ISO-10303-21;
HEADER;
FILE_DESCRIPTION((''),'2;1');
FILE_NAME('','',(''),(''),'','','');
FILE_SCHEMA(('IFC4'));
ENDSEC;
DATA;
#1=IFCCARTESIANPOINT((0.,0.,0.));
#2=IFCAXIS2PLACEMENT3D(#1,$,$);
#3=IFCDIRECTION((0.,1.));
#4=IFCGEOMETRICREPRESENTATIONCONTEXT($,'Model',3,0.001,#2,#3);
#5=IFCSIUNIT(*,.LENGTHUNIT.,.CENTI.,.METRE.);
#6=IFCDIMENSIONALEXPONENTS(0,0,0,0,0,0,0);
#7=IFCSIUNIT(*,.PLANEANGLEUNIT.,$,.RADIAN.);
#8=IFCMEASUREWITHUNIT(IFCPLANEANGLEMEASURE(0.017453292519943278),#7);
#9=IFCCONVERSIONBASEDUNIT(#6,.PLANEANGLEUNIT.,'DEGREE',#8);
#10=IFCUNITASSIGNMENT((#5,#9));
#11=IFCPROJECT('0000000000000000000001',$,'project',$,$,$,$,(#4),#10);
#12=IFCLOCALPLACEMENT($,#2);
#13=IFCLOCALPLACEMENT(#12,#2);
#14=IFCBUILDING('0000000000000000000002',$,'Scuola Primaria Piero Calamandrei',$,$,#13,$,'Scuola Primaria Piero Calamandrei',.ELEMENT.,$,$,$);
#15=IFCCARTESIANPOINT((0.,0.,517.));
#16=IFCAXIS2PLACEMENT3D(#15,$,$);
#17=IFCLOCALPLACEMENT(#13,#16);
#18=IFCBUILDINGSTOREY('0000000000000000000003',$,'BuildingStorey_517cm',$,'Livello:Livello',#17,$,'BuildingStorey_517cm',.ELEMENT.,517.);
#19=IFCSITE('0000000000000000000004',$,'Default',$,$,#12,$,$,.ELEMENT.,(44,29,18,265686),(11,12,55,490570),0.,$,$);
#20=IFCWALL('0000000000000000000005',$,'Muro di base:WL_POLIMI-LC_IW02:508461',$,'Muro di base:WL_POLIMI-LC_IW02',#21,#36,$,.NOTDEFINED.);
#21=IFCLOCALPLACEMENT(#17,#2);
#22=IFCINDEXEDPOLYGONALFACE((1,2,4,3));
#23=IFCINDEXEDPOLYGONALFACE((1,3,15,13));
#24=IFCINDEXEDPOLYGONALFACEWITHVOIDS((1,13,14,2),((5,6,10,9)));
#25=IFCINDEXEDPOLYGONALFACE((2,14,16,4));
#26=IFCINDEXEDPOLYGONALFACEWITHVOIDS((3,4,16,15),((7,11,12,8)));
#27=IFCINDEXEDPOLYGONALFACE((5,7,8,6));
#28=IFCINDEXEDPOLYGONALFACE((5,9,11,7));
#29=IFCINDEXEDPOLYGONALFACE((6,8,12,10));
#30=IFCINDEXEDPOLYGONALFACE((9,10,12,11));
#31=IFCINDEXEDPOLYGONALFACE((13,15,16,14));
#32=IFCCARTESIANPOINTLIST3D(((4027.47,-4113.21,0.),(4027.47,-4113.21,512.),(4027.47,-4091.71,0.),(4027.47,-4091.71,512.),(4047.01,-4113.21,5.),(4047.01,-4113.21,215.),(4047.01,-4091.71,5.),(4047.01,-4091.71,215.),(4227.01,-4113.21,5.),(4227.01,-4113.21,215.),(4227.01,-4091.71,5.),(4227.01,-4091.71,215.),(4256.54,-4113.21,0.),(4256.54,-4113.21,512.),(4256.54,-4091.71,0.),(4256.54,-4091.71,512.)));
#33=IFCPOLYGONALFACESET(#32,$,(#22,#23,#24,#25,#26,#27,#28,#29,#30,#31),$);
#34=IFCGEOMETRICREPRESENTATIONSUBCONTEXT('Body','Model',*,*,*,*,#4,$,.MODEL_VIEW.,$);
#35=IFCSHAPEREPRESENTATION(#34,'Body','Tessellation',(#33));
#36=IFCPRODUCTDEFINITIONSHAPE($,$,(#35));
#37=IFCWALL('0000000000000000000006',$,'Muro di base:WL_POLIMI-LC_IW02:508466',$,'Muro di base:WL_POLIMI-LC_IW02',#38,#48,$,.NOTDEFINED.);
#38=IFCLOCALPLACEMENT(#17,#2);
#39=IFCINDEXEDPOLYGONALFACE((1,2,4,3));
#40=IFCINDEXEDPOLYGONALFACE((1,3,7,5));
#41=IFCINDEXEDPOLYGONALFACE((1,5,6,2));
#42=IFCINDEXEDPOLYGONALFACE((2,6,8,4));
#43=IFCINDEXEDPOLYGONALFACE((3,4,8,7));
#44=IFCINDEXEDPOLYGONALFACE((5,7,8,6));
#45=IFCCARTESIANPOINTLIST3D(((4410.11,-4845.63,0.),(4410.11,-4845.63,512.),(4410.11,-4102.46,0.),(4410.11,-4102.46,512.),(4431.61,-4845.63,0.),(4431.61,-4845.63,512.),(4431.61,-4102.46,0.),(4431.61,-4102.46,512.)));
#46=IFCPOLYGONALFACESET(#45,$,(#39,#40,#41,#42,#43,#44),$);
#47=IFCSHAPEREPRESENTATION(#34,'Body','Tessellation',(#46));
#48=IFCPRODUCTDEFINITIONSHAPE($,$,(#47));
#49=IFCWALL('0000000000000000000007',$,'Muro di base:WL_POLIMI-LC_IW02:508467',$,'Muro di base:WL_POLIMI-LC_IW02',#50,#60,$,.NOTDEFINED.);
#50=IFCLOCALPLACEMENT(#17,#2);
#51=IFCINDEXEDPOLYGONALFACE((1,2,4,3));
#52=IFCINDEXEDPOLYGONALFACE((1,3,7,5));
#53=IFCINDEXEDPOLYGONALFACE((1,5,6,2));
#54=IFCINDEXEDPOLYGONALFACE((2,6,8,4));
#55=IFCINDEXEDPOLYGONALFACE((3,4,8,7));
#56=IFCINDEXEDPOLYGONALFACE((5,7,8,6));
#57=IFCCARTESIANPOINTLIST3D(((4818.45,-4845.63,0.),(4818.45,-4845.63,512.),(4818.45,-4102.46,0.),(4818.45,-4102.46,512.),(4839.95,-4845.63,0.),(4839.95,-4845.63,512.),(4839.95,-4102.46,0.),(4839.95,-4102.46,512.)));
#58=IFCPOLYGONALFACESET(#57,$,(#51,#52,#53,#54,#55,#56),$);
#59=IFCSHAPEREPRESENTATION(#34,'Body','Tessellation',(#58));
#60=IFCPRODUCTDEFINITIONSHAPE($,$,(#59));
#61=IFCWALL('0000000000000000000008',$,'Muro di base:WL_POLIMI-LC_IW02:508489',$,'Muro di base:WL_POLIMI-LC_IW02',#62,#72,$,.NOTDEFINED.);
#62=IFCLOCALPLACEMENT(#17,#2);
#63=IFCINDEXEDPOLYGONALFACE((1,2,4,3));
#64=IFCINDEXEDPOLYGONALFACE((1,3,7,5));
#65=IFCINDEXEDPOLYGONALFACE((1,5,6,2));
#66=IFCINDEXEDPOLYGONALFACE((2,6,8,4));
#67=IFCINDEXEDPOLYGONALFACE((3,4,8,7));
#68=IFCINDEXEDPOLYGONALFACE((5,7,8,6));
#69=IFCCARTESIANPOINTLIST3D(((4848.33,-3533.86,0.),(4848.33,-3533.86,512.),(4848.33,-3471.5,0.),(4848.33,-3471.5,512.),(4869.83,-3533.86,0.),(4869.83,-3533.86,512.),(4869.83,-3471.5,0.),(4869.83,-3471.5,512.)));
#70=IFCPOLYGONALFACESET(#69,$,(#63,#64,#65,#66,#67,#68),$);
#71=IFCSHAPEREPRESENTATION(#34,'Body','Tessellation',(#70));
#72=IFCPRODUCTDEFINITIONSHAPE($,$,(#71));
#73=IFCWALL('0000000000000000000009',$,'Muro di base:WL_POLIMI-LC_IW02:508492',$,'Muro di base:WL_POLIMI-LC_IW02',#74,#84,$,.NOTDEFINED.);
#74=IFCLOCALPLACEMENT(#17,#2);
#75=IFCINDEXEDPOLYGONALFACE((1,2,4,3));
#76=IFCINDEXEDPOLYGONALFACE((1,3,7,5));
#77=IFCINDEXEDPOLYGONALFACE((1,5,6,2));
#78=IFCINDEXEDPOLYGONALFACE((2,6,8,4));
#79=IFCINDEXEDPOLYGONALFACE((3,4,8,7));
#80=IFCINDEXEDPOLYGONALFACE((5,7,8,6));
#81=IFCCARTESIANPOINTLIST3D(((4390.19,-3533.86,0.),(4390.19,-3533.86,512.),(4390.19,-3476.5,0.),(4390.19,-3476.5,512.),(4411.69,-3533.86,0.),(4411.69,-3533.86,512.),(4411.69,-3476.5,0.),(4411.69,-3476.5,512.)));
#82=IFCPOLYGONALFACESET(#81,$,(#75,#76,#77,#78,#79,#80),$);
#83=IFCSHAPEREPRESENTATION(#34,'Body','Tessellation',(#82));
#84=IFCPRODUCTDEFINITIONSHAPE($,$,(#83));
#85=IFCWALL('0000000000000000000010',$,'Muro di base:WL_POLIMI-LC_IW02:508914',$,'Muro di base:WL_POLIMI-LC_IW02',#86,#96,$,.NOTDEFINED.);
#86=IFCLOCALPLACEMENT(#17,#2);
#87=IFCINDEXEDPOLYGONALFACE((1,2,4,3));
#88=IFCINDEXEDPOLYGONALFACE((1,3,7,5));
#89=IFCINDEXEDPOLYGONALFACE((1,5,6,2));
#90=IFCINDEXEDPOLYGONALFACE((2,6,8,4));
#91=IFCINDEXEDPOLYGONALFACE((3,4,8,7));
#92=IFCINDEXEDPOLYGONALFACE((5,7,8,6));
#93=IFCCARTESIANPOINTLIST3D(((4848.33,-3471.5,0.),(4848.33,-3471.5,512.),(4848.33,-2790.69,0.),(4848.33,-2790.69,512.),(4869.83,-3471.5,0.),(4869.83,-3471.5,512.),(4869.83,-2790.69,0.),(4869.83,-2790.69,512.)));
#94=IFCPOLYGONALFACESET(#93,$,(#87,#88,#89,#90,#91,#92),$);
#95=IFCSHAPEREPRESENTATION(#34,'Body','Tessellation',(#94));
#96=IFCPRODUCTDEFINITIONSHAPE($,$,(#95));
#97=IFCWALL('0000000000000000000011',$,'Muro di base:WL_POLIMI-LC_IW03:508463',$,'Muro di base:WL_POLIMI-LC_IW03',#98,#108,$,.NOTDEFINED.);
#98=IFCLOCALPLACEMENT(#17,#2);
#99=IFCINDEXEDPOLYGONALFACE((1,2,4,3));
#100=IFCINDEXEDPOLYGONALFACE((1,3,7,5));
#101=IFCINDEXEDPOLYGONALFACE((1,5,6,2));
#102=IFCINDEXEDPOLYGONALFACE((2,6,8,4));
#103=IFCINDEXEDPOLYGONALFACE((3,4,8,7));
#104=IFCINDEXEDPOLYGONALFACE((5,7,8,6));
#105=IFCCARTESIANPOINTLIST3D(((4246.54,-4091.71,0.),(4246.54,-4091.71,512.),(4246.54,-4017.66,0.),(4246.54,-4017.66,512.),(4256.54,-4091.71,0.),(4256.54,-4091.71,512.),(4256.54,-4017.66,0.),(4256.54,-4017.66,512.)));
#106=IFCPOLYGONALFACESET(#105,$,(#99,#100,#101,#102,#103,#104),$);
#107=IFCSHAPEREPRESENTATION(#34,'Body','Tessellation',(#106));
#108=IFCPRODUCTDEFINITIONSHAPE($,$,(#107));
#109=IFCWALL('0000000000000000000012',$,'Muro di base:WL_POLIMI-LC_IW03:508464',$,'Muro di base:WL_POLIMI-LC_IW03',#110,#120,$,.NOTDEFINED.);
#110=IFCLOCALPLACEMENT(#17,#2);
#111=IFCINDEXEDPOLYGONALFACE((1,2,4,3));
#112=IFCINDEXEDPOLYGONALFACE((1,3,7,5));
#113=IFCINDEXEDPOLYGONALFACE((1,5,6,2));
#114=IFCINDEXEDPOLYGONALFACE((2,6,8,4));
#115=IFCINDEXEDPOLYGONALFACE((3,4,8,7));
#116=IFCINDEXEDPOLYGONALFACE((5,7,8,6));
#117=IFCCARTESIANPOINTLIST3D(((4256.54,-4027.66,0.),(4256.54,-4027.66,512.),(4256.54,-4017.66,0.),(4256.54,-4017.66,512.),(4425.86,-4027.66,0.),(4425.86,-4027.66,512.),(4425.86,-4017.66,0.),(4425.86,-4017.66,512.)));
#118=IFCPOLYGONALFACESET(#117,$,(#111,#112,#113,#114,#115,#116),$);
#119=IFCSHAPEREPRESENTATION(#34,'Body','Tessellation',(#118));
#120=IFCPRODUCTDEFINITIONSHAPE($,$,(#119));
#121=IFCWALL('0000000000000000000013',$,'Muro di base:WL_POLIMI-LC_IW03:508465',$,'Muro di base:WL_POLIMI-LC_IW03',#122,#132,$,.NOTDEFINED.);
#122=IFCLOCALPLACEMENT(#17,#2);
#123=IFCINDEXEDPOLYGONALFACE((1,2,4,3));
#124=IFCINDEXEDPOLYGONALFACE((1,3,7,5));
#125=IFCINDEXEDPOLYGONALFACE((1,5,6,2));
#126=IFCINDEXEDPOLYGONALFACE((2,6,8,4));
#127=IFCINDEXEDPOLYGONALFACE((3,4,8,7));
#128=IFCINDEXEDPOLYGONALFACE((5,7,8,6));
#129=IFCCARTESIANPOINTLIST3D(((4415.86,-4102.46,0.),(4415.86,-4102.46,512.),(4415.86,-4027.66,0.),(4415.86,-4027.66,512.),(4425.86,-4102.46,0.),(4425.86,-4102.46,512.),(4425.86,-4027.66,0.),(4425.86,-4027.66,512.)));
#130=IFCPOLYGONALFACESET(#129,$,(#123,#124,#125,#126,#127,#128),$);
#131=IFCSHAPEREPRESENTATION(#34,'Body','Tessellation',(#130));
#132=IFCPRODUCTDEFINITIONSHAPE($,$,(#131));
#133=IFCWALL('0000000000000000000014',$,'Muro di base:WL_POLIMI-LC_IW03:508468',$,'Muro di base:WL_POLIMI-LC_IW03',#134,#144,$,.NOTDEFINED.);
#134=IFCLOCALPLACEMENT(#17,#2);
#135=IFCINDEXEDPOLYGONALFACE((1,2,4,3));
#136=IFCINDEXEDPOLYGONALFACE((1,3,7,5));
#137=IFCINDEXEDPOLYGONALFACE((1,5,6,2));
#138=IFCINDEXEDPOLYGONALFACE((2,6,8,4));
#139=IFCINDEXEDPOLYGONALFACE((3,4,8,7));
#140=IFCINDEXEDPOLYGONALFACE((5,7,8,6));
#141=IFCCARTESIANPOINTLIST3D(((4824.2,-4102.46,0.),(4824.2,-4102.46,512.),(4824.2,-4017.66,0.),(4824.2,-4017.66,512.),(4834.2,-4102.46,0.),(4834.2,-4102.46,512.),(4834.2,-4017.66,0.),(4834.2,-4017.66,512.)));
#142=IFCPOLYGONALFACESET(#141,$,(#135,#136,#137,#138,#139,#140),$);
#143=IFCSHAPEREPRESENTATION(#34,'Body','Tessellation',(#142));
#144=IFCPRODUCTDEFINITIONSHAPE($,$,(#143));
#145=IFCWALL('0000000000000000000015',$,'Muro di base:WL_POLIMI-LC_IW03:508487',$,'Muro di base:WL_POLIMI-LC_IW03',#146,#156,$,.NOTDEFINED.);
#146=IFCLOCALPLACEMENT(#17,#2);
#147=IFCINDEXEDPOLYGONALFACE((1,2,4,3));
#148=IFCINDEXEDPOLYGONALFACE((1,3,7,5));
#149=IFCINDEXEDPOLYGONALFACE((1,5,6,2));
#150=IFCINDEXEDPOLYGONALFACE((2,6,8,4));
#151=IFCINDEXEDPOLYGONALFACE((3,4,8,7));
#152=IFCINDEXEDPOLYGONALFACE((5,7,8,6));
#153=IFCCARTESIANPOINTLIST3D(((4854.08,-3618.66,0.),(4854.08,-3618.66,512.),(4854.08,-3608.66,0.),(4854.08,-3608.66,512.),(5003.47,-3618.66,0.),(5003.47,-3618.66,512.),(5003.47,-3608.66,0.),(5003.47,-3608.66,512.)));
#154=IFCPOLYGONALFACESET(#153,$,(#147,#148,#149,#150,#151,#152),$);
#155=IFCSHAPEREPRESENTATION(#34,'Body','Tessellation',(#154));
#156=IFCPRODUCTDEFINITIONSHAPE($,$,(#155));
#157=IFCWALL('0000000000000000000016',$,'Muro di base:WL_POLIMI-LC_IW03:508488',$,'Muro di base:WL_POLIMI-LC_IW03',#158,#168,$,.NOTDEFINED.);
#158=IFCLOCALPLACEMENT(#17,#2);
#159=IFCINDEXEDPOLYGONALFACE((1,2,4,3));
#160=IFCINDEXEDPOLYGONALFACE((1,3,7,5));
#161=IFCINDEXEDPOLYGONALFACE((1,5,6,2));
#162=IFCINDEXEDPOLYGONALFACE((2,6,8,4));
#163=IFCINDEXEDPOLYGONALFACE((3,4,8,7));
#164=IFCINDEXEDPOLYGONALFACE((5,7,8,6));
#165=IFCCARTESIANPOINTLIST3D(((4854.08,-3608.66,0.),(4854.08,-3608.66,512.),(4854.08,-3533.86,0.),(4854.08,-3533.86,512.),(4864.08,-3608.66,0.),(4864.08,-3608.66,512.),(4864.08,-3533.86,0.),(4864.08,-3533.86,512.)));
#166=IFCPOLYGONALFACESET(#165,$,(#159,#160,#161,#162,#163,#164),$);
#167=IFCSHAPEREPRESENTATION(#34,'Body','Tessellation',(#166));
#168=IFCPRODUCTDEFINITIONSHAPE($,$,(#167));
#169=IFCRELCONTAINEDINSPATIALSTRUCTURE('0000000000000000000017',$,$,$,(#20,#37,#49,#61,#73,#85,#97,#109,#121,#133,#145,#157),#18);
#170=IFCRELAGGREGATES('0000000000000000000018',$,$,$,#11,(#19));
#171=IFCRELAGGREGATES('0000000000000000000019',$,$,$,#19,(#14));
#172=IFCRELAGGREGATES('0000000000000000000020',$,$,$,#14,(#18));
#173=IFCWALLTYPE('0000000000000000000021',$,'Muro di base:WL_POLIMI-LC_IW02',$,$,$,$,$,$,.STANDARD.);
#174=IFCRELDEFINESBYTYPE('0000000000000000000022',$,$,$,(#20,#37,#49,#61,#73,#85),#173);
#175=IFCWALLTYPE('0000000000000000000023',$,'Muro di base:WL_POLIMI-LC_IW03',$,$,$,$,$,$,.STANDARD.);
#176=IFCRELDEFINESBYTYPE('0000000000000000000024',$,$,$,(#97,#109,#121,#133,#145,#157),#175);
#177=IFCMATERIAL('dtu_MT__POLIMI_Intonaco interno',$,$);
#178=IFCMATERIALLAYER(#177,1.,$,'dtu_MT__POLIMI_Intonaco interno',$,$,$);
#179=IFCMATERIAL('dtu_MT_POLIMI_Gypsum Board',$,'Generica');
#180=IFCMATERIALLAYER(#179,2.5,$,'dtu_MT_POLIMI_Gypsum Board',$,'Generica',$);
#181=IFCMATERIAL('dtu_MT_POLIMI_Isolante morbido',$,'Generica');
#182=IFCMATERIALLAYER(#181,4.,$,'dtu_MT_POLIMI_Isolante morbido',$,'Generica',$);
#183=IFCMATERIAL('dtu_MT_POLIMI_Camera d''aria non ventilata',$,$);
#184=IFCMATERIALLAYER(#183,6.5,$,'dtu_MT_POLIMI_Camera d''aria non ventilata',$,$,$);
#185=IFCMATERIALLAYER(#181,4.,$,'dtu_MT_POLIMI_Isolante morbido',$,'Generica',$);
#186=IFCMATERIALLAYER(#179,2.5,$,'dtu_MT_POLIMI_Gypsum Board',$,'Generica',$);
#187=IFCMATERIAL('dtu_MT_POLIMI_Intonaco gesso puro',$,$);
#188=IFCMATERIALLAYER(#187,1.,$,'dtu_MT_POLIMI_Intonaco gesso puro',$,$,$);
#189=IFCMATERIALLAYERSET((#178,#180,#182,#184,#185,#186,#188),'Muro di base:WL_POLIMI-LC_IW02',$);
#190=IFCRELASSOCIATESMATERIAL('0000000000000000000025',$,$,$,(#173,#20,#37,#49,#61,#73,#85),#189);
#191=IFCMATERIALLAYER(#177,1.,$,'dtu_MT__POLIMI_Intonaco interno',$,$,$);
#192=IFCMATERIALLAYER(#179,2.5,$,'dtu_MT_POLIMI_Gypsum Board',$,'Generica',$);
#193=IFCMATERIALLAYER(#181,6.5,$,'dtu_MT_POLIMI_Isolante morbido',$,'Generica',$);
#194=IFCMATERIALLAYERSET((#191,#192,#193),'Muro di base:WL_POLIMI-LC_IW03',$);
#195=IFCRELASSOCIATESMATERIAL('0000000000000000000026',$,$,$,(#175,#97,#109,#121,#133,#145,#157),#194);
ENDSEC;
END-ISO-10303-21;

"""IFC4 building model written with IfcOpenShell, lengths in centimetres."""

from ifc_helpers import new_model, entity, si_unit, converted_unit, direction, frame, frame_2d, origin, place, context, subcontext, project, spatial, rectangle, extrude, material, layer, layer_set, layer_usage, type_object, element, save


model = new_model("IFC4")

# Units and contexts
model_context = context("Model", 3, precision=0.001, world=origin(), true_north=direction((0.0, 1.0)))
body_context = subcontext(model_context, "Body", "Model", "MODEL_VIEW")
ifc_project = project(units=[si_unit("LENGTHUNIT", "METRE", prefix="CENTI"), converted_unit("PLANEANGLEUNIT", "DEGREE", entity("IfcPlaneAngleMeasure", 0.017453292519943278), si_unit("PLANEANGLEUNIT", "RADIAN"), dimensions=[0, 0, 0, 0, 0, 0, 0])], contexts=[model_context])

# Site, building, storey
site_placement = place(None, origin())
site = spatial("IfcSite", under=ifc_project, at=site_placement, Name="Default", CompositionType="ELEMENT", RefLatitude=(44, 29, 18, 265686), RefLongitude=(11, 12, 55, 490570), RefElevation=0.0)
building_placement = place(site_placement, origin())
building = spatial("IfcBuilding", under=site, at=building_placement, Name="Scuola Primaria Piero Calamandrei", LongName="Scuola Primaria Piero Calamandrei", CompositionType="ELEMENT")
storey_placement = place(building_placement, frame((0.0, 0.0, 517.0)))
storey = spatial("IfcBuildingStorey", under=building, at=storey_placement, Name="BuildingStorey_517cm", ObjectType="Livello:Livello", LongName="BuildingStorey_517cm", CompositionType="ELEMENT", Elevation=517.0)

# Shared definitions
ifc_material_1 = material(Name="dtu_MT_POLIMI_Isolante morbido", Category="Generica")
ifc_material_2 = material(Name="dtu_MT_POLIMI_Gypsum Board", Category="Generica")
ifc_material_3 = material(Name="dtu_MT__POLIMI_Intonaco interno")

# Wall, opening
ifc_layer_1 = layer(ifc_material_3, 1.0, Name="dtu_MT__POLIMI_Intonaco interno")
ifc_layer_2 = layer(ifc_material_2, 2.5, Name="dtu_MT_POLIMI_Gypsum Board", Category="Generica")
ifc_layer_3 = layer(ifc_material_1, 4.0, Name="dtu_MT_POLIMI_Isolante morbido", Category="Generica")
ifc_material_4 = material(Name="dtu_MT_POLIMI_Camera d'aria non ventilata")
ifc_layer_4 = layer(ifc_material_4, 6.5, Name="dtu_MT_POLIMI_Camera d'aria non ventilata")
ifc_layer_5 = layer(ifc_material_1, 4.0, Name="dtu_MT_POLIMI_Isolante morbido", Category="Generica")
ifc_layer_6 = layer(ifc_material_2, 2.5, Name="dtu_MT_POLIMI_Gypsum Board", Category="Generica")
ifc_material_5 = material(Name="dtu_MT_POLIMI_Intonaco gesso puro")
ifc_layer_7 = layer(ifc_material_5, 1.0, Name="dtu_MT_POLIMI_Intonaco gesso puro")
ifc_layer_set_1 = layer_set([ifc_layer_1, ifc_layer_2, ifc_layer_3, ifc_layer_4, ifc_layer_5, ifc_layer_6, ifc_layer_7], Name="Muro di base:WL_POLIMI-LC_IW02")
ifc_layer_usage_1 = layer_usage(ifc_layer_set_1, "AXIS2", "NEGATIVE", 10.75)
wall_type_1 = type_object("IfcWallType", Name="Muro di base:WL_POLIMI-LC_IW02", PredefinedType="STANDARD", material=ifc_layer_set_1)
wall_1_placement = place(storey_placement, frame((4256.54, -4102.46, 0.0), z_axis=(0.0, 0.0, 1.0), x_axis=(-1.0, 0.0, 0.0)))
wall_1 = element("IfcWall", 1, at=wall_1_placement, inside=storey, type_object=wall_type_1, material=ifc_layer_usage_1, Name="Muro di base:WL_POLIMI-LC_IW02:508461", ObjectType="Muro di base:WL_POLIMI-LC_IW02", PredefinedType="NOTDEFINED", context=body_context, shape_type="SweptSolid", body=[
    extrude(rectangle(XDim=229.07, YDim=21.5, at=frame_2d((114.54, 0.0), x_axis=(-1.0, 0.0))), origin(), (0.0, 0.0, 1.0), 512.0),
])
opening_1_placement = place(wall_1_placement, frame((209.54, 10.75, 5.0)))
element("IfcOpeningElement", 2, at=opening_1_placement, cuts=wall_1, PredefinedType="OPENING", context=body_context, shape_type="SweptSolid", body=[
    extrude(rectangle(XDim=210.0, YDim=180.0, at=frame_2d((105.0, 90.0), x_axis=(-1.0, 0.0))), frame((0.0, 0.0, 0.0), z_axis=(0.0, -1.0, 0.0), x_axis=(0.0, 0.0, 1.0)), (0.0, 0.0, 1.0), 21.5),
])

# Walls
ifc_layer_usage_2 = layer_usage(ifc_layer_set_1, "AXIS2", "NEGATIVE", 10.75)
wall_2_placement = place(storey_placement, frame((4420.86, -4845.63, 0.0), z_axis=(0.0, 0.0, 1.0), x_axis=(0.0, 1.0, 0.0)))
element("IfcWall", 3, at=wall_2_placement, inside=storey, type_object=wall_type_1, material=ifc_layer_usage_2, Name="Muro di base:WL_POLIMI-LC_IW02:508466", ObjectType="Muro di base:WL_POLIMI-LC_IW02", PredefinedType="NOTDEFINED", context=body_context, shape_type="SweptSolid", body=[
    extrude(rectangle(XDim=743.17, YDim=21.5, at=frame_2d((371.58, 0.0), x_axis=(-1.0, 0.0))), origin(), (0.0, 0.0, 1.0), 512.0),
])
ifc_layer_usage_3 = layer_usage(ifc_layer_set_1, "AXIS2", "NEGATIVE", 10.75)
wall_3_placement = place(storey_placement, frame((4829.2, -4102.46, 0.0), z_axis=(0.0, 0.0, 1.0), x_axis=(0.0, -1.0, 0.0)))
element("IfcWall", 4, at=wall_3_placement, inside=storey, type_object=wall_type_1, material=ifc_layer_usage_3, Name="Muro di base:WL_POLIMI-LC_IW02:508467", ObjectType="Muro di base:WL_POLIMI-LC_IW02", PredefinedType="NOTDEFINED", context=body_context, shape_type="SweptSolid", body=[
    extrude(rectangle(XDim=743.17, YDim=21.5, at=frame_2d((371.58, 0.0), x_axis=(-1.0, 0.0))), origin(), (0.0, 0.0, 1.0), 512.0),
])
ifc_layer_usage_4 = layer_usage(ifc_layer_set_1, "AXIS2", "NEGATIVE", 10.75)
wall_4_placement = place(storey_placement, frame((4859.08, -3471.5, 0.0), z_axis=(0.0, 0.0, 1.0), x_axis=(0.0, -1.0, 0.0)))
element("IfcWall", 5, at=wall_4_placement, inside=storey, type_object=wall_type_1, material=ifc_layer_usage_4, Name="Muro di base:WL_POLIMI-LC_IW02:508489", ObjectType="Muro di base:WL_POLIMI-LC_IW02", PredefinedType="NOTDEFINED", context=body_context, shape_type="SweptSolid", body=[
    extrude(rectangle(XDim=62.35, YDim=21.5, at=frame_2d((31.18, 0.0), x_axis=(-1.0, 0.0))), origin(), (0.0, 0.0, 1.0), 512.0),
])
ifc_layer_usage_5 = layer_usage(ifc_layer_set_1, "AXIS2", "NEGATIVE", 10.75)
wall_5_placement = place(storey_placement, frame((4400.94, -3533.86, 0.0), z_axis=(0.0, 0.0, 1.0), x_axis=(0.0, 1.0, 0.0)))
element("IfcWall", 6, at=wall_5_placement, inside=storey, type_object=wall_type_1, material=ifc_layer_usage_5, Name="Muro di base:WL_POLIMI-LC_IW02:508492", ObjectType="Muro di base:WL_POLIMI-LC_IW02", PredefinedType="NOTDEFINED", context=body_context, shape_type="SweptSolid", body=[
    extrude(rectangle(XDim=57.35, YDim=21.5, at=frame_2d((28.68, 0.0), x_axis=(-1.0, 0.0))), origin(), (0.0, 0.0, 1.0), 512.0),
])
ifc_layer_usage_6 = layer_usage(ifc_layer_set_1, "AXIS2", "NEGATIVE", 10.75)
wall_6_placement = place(storey_placement, frame((4859.08, -3471.5, 0.0), z_axis=(0.0, 0.0, 1.0), x_axis=(0.0, 1.0, 0.0)))
element("IfcWall", 7, at=wall_6_placement, inside=storey, type_object=wall_type_1, material=ifc_layer_usage_6, Name="Muro di base:WL_POLIMI-LC_IW02:508914", ObjectType="Muro di base:WL_POLIMI-LC_IW02", PredefinedType="NOTDEFINED", context=body_context, shape_type="SweptSolid", body=[
    extrude(rectangle(XDim=680.81, YDim=21.5, at=frame_2d((340.41, 0.0), x_axis=(-1.0, 0.0))), origin(), (0.0, 0.0, 1.0), 512.0),
])
ifc_layer_8 = layer(ifc_material_3, 1.0, Name="dtu_MT__POLIMI_Intonaco interno")
ifc_layer_9 = layer(ifc_material_2, 2.5, Name="dtu_MT_POLIMI_Gypsum Board", Category="Generica")
ifc_layer_10 = layer(ifc_material_1, 6.5, Name="dtu_MT_POLIMI_Isolante morbido", Category="Generica")
ifc_layer_set_2 = layer_set([ifc_layer_8, ifc_layer_9, ifc_layer_10], Name="Muro di base:WL_POLIMI-LC_IW03")
ifc_layer_usage_7 = layer_usage(ifc_layer_set_2, "AXIS2", "NEGATIVE", 5.0)
wall_type_2 = type_object("IfcWallType", Name="Muro di base:WL_POLIMI-LC_IW03", PredefinedType="STANDARD", material=ifc_layer_set_2)
wall_7_placement = place(storey_placement, frame((4251.54, -4017.66, 0.0), z_axis=(0.0, 0.0, 1.0), x_axis=(0.0, -1.0, 0.0)))
element("IfcWall", 8, at=wall_7_placement, inside=storey, type_object=wall_type_2, material=ifc_layer_usage_7, Name="Muro di base:WL_POLIMI-LC_IW03:508463", ObjectType="Muro di base:WL_POLIMI-LC_IW03", PredefinedType="NOTDEFINED", context=body_context, shape_type="SweptSolid", body=[
    extrude(rectangle(XDim=74.05, YDim=10.0, at=frame_2d((37.03, 0.0), x_axis=(-1.0, 0.0))), origin(), (0.0, 0.0, 1.0), 512.0),
])
ifc_layer_usage_8 = layer_usage(ifc_layer_set_2, "AXIS2", "NEGATIVE", 5.0)
wall_8_placement = place(storey_placement, frame((4425.86, -4022.66, 0.0), z_axis=(0.0, 0.0, 1.0), x_axis=(-1.0, 0.0, 0.0)))
element("IfcWall", 9, at=wall_8_placement, inside=storey, type_object=wall_type_2, material=ifc_layer_usage_8, Name="Muro di base:WL_POLIMI-LC_IW03:508464", ObjectType="Muro di base:WL_POLIMI-LC_IW03", PredefinedType="NOTDEFINED", context=body_context, shape_type="SweptSolid", body=[
    extrude(rectangle(XDim=169.31, YDim=10.0, at=frame_2d((84.66, 0.0), x_axis=(-1.0, 0.0))), origin(), (0.0, 0.0, 1.0), 512.0),
])
ifc_layer_usage_9 = layer_usage(ifc_layer_set_2, "AXIS2", "NEGATIVE", 5.0)
wall_9_placement = place(storey_placement, frame((4420.86, -4102.46, 0.0), z_axis=(0.0, 0.0, 1.0), x_axis=(0.0, 1.0, 0.0)))
element("IfcWall", 10, at=wall_9_placement, inside=storey, type_object=wall_type_2, material=ifc_layer_usage_9, Name="Muro di base:WL_POLIMI-LC_IW03:508465", ObjectType="Muro di base:WL_POLIMI-LC_IW03", PredefinedType="NOTDEFINED", context=body_context, shape_type="SweptSolid", body=[
    extrude(rectangle(XDim=74.8, YDim=10.0, at=frame_2d((37.4, 0.0), x_axis=(-1.0, 0.0))), origin(), (0.0, 0.0, 1.0), 512.0),
])
ifc_layer_usage_10 = layer_usage(ifc_layer_set_2, "AXIS2", "NEGATIVE", 5.0)
wall_10_placement = place(storey_placement, frame((4829.2, -4017.66, 0.0), z_axis=(0.0, 0.0, 1.0), x_axis=(0.0, -1.0, 0.0)))
element("IfcWall", 11, at=wall_10_placement, inside=storey, type_object=wall_type_2, material=ifc_layer_usage_10, Name="Muro di base:WL_POLIMI-LC_IW03:508468", ObjectType="Muro di base:WL_POLIMI-LC_IW03", PredefinedType="NOTDEFINED", context=body_context, shape_type="SweptSolid", body=[
    extrude(rectangle(XDim=84.8, YDim=10.0, at=frame_2d((42.4, 0.0), x_axis=(-1.0, 0.0))), origin(), (0.0, 0.0, 1.0), 512.0),
])
ifc_layer_usage_11 = layer_usage(ifc_layer_set_2, "AXIS2", "NEGATIVE", 5.0)
wall_11_placement = place(storey_placement, frame((4854.08, -3613.66, 0.0)))
element("IfcWall", 12, at=wall_11_placement, inside=storey, type_object=wall_type_2, material=ifc_layer_usage_11, Name="Muro di base:WL_POLIMI-LC_IW03:508487", ObjectType="Muro di base:WL_POLIMI-LC_IW03", PredefinedType="NOTDEFINED", context=body_context, shape_type="SweptSolid", body=[
    extrude(rectangle(XDim=149.39, YDim=10.0, at=frame_2d((74.7, 0.0), x_axis=(-1.0, 0.0))), origin(), (0.0, 0.0, 1.0), 512.0),
])
ifc_layer_usage_12 = layer_usage(ifc_layer_set_2, "AXIS2", "NEGATIVE", 5.0)
wall_12_placement = place(storey_placement, frame((4859.08, -3533.86, 0.0), z_axis=(0.0, 0.0, 1.0), x_axis=(0.0, -1.0, 0.0)))
element("IfcWall", 13, at=wall_12_placement, inside=storey, type_object=wall_type_2, material=ifc_layer_usage_12, Name="Muro di base:WL_POLIMI-LC_IW03:508488", ObjectType="Muro di base:WL_POLIMI-LC_IW03", PredefinedType="NOTDEFINED", context=body_context, shape_type="SweptSolid", body=[
    extrude(rectangle(XDim=74.8, YDim=10.0, at=frame_2d((37.4, 0.0), x_axis=(-1.0, 0.0))), origin(), (0.0, 0.0, 1.0), 512.0),
])

save(model, "model.ifc")
